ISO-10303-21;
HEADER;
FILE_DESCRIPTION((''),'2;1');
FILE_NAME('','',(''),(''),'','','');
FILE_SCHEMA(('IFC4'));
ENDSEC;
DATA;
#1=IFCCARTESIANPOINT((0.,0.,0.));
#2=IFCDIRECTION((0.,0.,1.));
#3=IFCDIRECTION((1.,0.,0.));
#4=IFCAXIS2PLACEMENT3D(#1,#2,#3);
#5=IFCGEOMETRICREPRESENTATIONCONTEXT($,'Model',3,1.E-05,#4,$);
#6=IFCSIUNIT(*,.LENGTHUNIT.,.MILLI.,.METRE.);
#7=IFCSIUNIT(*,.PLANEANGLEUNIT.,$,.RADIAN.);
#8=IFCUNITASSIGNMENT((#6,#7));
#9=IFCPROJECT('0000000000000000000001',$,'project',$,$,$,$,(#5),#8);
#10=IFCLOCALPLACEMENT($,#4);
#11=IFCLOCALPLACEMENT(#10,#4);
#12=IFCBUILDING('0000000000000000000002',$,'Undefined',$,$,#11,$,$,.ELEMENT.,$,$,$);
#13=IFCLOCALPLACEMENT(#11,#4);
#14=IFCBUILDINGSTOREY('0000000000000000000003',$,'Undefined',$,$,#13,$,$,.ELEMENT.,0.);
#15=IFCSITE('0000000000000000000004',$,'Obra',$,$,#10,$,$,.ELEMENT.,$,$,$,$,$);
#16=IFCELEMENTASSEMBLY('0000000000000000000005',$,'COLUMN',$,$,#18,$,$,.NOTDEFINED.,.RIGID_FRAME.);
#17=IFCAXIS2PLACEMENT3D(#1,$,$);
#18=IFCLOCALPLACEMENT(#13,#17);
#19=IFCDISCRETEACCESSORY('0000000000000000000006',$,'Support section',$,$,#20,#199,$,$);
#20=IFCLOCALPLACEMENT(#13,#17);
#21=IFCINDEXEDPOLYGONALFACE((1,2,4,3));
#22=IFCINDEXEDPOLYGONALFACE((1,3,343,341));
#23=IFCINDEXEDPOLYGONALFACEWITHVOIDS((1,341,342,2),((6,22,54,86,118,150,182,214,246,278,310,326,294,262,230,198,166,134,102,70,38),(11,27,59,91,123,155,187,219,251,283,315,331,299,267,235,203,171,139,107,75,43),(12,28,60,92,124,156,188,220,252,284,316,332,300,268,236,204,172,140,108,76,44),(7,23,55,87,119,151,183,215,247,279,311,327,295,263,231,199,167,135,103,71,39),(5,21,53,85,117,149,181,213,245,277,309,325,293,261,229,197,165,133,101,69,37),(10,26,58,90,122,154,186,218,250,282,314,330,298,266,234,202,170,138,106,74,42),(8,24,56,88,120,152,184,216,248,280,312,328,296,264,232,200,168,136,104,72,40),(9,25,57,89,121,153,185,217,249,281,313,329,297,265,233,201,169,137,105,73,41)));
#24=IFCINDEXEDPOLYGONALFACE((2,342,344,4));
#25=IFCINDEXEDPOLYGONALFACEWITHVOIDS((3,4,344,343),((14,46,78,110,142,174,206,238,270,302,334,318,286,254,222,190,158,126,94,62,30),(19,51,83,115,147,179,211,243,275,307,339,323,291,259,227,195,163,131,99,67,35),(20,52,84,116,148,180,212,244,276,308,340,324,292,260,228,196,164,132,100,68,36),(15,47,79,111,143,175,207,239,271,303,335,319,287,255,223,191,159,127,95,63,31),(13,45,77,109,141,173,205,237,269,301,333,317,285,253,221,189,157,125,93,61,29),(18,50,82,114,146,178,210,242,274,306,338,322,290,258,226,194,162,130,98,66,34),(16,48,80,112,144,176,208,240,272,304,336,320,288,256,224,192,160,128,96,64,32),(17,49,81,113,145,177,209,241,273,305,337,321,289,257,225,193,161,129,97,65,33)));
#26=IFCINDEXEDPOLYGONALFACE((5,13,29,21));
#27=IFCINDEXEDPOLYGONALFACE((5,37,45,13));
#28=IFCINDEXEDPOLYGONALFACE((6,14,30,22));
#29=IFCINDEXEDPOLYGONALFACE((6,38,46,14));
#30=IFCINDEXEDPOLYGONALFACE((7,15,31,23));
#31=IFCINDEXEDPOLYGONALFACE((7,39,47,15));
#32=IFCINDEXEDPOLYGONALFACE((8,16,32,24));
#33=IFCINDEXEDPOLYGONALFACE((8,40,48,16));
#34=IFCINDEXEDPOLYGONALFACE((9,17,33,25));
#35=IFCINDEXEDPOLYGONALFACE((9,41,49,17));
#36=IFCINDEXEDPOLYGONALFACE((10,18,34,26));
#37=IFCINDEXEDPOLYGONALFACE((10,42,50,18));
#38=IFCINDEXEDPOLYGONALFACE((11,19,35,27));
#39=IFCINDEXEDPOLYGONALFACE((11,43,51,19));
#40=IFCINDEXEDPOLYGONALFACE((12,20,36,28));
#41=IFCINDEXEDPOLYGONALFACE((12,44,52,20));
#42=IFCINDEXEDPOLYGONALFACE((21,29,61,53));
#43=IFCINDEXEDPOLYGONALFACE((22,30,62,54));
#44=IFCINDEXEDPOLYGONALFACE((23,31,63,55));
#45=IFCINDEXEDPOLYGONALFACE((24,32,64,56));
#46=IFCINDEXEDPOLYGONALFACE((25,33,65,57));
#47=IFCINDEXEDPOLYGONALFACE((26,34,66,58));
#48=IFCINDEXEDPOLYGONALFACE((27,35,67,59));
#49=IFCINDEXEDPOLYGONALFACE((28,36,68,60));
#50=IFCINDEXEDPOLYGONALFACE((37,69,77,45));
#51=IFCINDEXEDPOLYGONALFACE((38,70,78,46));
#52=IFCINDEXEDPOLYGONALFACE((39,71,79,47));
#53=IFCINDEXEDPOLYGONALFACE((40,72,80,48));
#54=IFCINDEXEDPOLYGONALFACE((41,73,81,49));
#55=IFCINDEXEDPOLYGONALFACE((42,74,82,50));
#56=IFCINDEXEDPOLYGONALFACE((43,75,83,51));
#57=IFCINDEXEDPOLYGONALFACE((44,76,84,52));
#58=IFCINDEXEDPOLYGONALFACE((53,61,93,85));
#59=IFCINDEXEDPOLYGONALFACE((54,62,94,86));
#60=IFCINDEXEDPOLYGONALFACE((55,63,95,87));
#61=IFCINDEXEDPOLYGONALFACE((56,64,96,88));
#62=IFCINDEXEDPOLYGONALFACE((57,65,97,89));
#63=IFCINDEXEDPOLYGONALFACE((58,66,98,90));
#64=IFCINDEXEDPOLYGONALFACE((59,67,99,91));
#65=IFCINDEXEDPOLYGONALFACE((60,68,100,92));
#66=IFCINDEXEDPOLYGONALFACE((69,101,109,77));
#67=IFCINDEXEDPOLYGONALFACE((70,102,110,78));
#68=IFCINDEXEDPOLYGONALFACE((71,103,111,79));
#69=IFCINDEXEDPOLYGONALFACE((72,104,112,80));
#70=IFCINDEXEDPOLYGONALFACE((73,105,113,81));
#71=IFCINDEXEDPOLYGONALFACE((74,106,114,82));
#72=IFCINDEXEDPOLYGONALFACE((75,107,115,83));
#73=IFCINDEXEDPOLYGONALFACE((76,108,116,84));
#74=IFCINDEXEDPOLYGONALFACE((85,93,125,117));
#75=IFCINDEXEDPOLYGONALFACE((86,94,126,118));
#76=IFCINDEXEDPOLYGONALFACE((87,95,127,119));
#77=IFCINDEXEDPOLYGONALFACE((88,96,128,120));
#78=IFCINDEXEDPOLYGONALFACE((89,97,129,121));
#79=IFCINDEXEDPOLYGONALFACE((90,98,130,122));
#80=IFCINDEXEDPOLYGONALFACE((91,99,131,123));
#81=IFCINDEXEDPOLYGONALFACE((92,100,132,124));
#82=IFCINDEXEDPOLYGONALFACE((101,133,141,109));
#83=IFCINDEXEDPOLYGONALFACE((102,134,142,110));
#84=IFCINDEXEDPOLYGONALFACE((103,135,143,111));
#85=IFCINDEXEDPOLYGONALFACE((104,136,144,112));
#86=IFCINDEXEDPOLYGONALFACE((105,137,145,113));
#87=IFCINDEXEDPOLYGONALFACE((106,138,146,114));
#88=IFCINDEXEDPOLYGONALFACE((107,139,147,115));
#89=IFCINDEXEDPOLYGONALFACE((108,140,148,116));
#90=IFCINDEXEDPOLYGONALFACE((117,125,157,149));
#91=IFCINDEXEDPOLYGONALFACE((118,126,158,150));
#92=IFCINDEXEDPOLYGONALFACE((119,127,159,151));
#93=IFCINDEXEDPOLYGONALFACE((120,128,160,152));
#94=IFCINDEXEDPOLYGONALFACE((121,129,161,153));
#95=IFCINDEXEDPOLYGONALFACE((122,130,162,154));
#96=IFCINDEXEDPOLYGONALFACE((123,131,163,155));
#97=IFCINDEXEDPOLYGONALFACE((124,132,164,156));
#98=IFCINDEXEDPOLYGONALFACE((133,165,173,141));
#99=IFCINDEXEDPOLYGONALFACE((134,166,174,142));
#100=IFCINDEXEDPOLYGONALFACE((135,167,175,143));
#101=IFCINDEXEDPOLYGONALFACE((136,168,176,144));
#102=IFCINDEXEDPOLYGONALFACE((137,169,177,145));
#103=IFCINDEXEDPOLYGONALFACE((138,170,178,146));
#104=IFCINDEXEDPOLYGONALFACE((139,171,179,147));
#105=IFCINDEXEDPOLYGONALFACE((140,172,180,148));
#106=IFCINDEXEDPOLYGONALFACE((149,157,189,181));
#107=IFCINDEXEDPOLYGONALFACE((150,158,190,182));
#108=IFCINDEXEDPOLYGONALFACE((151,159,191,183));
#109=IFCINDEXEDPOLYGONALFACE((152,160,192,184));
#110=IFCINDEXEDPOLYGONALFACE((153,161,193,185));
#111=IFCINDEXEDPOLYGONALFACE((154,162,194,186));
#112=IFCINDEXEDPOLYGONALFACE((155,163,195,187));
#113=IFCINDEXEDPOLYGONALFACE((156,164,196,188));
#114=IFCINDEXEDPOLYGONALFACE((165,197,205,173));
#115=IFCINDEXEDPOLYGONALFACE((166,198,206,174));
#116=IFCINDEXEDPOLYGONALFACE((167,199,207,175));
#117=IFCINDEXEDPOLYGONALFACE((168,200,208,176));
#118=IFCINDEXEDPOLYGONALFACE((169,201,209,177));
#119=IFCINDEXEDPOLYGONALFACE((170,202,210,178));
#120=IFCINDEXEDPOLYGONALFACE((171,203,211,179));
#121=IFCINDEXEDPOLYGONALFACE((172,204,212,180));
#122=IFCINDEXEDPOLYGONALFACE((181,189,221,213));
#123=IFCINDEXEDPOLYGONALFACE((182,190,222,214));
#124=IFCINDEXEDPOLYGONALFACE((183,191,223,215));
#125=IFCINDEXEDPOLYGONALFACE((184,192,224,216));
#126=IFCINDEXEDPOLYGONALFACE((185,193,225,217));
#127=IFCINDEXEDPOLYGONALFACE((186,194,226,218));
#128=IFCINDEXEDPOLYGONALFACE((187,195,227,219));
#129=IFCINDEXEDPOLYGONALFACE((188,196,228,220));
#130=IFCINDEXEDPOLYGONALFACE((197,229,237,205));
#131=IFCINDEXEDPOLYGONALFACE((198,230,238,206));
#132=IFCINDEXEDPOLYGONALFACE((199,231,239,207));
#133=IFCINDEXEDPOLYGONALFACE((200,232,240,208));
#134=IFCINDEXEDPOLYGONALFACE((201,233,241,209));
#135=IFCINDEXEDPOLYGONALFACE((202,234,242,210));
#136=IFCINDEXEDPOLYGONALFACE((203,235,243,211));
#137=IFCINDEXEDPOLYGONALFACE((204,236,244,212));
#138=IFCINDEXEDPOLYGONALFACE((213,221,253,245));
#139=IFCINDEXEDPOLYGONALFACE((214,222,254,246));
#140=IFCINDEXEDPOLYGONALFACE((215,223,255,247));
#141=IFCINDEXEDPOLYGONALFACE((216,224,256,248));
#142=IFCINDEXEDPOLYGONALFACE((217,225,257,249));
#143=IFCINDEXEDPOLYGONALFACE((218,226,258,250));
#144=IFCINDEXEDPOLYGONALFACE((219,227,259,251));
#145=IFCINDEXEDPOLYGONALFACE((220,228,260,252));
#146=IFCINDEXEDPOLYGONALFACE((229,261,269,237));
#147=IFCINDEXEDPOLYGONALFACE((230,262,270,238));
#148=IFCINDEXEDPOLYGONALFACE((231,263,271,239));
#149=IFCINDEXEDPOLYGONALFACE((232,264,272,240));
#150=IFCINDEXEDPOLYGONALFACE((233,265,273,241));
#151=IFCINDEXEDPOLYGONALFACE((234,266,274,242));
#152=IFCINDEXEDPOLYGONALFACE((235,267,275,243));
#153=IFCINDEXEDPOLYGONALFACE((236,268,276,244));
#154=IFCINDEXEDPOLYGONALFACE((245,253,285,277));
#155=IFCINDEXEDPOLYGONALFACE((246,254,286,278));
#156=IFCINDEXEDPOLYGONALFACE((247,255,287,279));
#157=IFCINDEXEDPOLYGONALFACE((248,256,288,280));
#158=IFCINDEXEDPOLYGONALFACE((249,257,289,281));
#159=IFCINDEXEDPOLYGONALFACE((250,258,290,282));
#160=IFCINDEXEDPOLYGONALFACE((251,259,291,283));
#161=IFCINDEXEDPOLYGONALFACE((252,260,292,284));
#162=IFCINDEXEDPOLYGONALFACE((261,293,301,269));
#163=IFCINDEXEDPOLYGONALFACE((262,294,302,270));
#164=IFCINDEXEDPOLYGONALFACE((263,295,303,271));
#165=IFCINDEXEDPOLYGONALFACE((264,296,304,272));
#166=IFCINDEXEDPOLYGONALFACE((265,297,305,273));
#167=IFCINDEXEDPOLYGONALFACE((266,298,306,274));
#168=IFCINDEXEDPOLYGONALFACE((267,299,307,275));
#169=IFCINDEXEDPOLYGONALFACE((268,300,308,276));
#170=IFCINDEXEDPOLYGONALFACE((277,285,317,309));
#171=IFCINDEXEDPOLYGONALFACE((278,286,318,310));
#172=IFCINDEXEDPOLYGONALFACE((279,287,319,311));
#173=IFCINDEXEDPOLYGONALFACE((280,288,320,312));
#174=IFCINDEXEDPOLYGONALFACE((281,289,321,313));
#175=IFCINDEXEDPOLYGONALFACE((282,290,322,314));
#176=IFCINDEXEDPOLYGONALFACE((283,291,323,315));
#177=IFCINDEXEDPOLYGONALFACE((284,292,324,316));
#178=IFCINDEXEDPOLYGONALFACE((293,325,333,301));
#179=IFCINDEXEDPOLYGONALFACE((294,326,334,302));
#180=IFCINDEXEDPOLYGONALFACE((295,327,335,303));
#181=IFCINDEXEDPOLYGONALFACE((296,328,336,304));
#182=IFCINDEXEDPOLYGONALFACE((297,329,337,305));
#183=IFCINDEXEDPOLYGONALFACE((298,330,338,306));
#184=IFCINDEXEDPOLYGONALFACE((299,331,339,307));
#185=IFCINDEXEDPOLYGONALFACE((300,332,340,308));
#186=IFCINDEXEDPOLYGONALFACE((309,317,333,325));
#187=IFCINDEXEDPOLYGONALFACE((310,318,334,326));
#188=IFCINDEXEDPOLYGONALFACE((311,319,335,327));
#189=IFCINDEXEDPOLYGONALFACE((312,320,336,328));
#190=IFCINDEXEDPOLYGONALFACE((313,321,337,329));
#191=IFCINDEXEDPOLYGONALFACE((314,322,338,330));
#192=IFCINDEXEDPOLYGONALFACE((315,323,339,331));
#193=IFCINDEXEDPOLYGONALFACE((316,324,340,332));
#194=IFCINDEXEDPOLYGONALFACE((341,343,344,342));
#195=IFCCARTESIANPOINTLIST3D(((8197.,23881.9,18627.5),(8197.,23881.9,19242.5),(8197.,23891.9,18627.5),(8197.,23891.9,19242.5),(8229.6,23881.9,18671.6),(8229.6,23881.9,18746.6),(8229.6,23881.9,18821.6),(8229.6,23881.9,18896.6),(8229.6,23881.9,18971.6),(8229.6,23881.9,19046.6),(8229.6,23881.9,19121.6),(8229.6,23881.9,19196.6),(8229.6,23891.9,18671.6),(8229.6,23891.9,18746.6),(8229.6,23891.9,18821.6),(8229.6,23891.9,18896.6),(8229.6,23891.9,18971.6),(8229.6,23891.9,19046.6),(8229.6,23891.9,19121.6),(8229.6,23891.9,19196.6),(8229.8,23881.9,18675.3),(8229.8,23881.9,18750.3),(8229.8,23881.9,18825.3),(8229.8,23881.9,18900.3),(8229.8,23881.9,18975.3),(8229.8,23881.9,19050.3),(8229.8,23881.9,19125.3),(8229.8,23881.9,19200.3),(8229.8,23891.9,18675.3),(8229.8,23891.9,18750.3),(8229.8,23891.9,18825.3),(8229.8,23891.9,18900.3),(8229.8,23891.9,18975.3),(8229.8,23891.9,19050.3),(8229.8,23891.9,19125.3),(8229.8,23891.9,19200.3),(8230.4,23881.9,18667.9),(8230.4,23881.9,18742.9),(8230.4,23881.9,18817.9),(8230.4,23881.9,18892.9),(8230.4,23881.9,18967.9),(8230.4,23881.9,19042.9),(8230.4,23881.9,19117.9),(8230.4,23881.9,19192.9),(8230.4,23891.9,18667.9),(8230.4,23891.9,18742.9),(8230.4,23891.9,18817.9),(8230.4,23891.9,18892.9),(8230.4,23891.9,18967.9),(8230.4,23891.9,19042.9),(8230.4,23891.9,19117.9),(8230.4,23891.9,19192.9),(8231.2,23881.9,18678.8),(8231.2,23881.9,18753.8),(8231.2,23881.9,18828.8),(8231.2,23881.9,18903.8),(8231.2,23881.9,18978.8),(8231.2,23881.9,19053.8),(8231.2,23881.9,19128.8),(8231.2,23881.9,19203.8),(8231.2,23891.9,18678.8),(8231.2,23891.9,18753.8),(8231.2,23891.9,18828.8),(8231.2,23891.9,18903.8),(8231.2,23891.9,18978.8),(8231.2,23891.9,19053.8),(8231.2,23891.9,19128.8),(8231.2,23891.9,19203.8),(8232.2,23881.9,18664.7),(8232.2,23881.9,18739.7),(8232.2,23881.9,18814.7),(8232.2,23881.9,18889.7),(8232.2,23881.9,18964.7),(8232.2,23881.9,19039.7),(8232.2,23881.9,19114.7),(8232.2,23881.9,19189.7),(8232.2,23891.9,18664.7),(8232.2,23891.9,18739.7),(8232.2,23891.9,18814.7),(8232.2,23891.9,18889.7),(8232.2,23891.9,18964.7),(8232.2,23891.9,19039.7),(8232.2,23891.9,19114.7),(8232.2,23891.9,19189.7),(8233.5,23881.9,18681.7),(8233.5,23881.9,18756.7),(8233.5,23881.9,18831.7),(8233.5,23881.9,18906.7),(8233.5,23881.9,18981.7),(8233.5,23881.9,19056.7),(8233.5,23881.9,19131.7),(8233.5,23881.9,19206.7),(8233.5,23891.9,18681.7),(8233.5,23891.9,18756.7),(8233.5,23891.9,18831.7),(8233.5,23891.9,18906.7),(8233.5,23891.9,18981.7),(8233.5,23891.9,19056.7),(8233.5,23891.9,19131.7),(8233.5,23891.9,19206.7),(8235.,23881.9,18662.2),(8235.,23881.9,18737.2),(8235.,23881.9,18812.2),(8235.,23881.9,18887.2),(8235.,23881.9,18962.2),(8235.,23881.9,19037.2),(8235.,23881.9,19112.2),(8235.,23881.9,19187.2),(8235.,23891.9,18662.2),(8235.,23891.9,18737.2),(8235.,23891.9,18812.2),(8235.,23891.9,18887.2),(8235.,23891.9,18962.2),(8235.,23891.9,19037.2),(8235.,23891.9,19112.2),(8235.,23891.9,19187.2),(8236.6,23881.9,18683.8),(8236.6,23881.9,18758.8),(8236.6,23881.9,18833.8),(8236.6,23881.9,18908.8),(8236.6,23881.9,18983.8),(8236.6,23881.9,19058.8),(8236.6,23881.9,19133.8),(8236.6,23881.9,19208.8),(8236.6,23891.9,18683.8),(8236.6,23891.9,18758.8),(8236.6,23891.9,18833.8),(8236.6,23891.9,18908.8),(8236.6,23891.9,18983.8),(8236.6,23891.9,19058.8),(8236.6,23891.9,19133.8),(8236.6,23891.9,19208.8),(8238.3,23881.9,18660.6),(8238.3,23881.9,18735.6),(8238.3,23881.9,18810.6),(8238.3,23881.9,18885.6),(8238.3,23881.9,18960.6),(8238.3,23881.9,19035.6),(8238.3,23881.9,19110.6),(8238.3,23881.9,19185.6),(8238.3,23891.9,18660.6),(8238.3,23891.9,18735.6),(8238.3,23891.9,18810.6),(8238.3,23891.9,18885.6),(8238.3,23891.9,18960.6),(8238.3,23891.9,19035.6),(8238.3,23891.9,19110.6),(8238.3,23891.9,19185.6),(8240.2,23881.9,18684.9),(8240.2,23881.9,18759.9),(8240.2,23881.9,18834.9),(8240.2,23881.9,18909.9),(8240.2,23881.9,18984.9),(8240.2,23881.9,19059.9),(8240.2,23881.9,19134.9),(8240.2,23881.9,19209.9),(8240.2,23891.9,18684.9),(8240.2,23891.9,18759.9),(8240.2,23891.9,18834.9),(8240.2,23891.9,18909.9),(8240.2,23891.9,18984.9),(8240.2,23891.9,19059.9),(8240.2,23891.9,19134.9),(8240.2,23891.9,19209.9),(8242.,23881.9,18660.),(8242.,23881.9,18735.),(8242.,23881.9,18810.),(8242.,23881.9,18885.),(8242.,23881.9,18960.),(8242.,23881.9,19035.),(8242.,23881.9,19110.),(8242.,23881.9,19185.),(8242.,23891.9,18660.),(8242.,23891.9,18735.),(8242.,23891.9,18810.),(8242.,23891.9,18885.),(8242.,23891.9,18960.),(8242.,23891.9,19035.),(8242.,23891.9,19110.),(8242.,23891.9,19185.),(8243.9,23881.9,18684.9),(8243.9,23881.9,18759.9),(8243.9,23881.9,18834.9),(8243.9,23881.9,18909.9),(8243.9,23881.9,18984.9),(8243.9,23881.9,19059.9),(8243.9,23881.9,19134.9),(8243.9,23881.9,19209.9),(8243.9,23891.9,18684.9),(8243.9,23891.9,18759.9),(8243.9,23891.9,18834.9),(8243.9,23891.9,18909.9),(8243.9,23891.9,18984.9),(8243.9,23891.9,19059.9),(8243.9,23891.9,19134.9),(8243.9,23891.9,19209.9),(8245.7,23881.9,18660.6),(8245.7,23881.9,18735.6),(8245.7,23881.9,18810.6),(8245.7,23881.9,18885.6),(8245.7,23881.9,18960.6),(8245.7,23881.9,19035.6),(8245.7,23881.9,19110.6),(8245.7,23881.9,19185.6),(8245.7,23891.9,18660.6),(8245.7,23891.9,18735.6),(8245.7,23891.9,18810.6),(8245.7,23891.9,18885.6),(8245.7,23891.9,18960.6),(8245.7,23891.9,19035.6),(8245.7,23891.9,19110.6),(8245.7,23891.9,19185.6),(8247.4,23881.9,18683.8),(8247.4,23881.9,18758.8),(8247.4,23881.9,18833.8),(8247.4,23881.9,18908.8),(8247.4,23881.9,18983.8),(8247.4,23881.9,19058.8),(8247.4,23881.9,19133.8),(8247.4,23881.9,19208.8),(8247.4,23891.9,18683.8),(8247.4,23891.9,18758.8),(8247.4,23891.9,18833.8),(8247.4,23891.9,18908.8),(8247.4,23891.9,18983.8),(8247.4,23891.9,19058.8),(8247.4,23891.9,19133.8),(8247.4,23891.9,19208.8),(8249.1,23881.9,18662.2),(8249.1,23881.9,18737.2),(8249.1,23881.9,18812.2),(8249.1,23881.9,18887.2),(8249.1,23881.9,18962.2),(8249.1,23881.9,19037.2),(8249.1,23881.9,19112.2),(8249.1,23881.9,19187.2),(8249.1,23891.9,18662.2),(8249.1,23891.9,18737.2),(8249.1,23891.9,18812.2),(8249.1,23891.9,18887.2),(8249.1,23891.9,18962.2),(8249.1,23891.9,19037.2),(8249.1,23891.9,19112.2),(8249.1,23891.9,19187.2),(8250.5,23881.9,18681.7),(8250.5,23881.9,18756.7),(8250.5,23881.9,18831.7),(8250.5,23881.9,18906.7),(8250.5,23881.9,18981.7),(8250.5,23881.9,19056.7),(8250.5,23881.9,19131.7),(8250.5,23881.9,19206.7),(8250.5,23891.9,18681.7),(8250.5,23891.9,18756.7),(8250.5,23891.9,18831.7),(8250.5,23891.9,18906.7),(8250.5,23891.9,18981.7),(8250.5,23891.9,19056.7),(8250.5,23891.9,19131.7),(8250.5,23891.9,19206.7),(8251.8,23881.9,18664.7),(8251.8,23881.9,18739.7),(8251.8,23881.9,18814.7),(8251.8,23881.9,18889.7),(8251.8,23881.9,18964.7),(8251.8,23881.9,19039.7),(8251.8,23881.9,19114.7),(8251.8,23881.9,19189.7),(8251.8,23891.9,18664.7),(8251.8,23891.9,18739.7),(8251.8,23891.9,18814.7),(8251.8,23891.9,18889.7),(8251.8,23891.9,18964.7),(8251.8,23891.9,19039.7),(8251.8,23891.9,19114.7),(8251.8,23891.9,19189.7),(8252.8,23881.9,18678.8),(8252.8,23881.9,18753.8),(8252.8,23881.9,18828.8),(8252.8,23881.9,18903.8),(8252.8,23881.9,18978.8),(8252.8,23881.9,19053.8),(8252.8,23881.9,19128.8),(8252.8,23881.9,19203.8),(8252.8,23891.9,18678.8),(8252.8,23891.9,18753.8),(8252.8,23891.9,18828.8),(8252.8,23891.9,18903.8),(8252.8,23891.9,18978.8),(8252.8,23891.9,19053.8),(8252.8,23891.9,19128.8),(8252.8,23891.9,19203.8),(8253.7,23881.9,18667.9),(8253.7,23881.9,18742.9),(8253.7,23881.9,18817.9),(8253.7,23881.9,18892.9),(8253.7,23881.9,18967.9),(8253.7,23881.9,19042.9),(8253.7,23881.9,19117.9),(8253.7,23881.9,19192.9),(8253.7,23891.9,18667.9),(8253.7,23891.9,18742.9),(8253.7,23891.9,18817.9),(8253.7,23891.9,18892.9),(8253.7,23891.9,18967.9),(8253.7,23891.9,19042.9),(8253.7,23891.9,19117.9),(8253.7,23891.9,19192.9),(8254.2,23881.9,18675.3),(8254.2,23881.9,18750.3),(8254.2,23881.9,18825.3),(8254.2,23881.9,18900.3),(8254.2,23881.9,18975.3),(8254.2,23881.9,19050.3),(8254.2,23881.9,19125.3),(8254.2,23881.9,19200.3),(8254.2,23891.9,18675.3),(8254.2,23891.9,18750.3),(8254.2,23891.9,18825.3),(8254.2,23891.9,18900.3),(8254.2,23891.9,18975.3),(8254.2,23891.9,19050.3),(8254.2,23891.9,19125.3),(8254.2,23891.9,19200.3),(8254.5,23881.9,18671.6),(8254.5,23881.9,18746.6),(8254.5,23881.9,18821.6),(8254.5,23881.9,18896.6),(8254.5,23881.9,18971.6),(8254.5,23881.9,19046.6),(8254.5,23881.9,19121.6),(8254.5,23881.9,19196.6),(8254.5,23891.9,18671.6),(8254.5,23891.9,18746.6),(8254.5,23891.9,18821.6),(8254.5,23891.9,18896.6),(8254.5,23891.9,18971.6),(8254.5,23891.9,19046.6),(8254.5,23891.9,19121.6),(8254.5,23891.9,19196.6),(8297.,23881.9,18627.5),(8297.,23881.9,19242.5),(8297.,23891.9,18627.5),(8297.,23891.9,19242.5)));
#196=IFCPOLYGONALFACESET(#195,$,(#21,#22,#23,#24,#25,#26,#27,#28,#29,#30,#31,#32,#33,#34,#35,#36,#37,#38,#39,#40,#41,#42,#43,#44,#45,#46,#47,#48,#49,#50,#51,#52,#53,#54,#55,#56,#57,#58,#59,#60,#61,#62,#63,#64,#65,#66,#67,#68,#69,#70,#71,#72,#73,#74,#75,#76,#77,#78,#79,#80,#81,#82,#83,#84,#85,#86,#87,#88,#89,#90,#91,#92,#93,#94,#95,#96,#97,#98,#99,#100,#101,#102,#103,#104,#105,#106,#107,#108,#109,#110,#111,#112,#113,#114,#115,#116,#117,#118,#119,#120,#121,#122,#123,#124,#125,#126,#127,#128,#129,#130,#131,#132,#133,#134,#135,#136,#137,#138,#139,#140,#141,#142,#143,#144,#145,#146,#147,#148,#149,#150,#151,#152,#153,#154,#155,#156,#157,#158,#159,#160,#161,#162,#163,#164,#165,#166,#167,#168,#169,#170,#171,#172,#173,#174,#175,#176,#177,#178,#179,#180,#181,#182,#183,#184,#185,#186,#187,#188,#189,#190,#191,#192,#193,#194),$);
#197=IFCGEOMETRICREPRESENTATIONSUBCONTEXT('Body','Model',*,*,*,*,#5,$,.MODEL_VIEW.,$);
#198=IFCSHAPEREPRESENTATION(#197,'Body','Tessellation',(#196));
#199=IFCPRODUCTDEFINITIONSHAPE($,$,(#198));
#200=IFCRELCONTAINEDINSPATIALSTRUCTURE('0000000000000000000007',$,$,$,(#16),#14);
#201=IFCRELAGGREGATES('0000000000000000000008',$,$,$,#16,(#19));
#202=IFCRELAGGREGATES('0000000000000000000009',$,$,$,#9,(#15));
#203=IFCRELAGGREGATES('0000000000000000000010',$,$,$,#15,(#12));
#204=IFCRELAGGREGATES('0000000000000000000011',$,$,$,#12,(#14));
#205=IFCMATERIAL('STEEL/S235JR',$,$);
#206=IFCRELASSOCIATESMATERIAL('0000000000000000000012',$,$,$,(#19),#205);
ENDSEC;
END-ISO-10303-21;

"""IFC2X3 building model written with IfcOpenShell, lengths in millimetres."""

from ifc_helpers import new_model, si_unit, frame, origin_with_axes, origin_2d_with_axis, place, context, subcontext, project, spatial, rectangle, circle, extrude, source, transform, mapped, material, element, aggregate, save


model = new_model("IFC2X3")

# Units and contexts
model_context = context("Model", 3, precision=1e-05, world=origin_with_axes())
body_context = subcontext(model_context, "Body", "Model", "MODEL_VIEW")
ifc_project = project(units=[si_unit("LENGTHUNIT", "METRE", prefix="MILLI"), si_unit("PLANEANGLEUNIT", "RADIAN")], contexts=[model_context])

# Site, building, storey
site_placement = place(None, origin_with_axes())
site = spatial("IfcSite", under=ifc_project, at=site_placement, Name="Obra", CompositionType="ELEMENT")
building_placement = place(site_placement, origin_with_axes())
building = spatial("IfcBuilding", under=site, at=building_placement, Name="Undefined", CompositionType="ELEMENT")
storey_placement = place(building_placement, origin_with_axes())
storey = spatial("IfcBuildingStorey", under=building, at=storey_placement, Name="Undefined", CompositionType="ELEMENT", Elevation=0.0)

# Element assembly
assembly_1_placement = place(storey_placement, origin_with_axes())
assembly_1 = element("IfcElementAssembly", 1, at=assembly_1_placement, inside=storey, Name="COLUMN", AssemblyPlace="NOTDEFINED", PredefinedType="RIGID_FRAME")
ifc_material_1 = material(Name="STEEL/S235JR")

# Discrete accessory, opening
discrete_accessory_1_placement = place(assembly_1_placement, frame((8247.0, 23886.9, 18627.5), z_axis=(0.0, 0.0, 1.0), x_axis=(1.0, 0.0, 0.0)))
discrete_accessory_1 = element("IfcDiscreteAccessory", 2, at=discrete_accessory_1_placement, material=ifc_material_1, Name="Support section", context=body_context, shape_type="SweptSolid", body=[
    extrude(rectangle(XDim=10.0, YDim=100.0, at=origin_2d_with_axis()), frame((0.0, 0.0, 615.0), z_axis=(0.0, 0.0, -1.0), x_axis=(0.0, 1.0, 0.0)), (0.0, 0.0, 1.0), 615.0),
])
shared_shape_1 = source(origin_with_axes(), body_context, "Body", "SweptSolid", [
    extrude(circle(Radius=12.5, at=origin_2d_with_axis()), frame((0.0, 4.9, 0.0), z_axis=(0.0, 1.0, 0.0), x_axis=(1.0, 0.0, 0.0)), (0.0, 0.0, 1.0), 10.2),
])
opening_1_placement = place(assembly_1_placement, frame((8287.0, 23896.9, 19350.0), z_axis=(-1.0, 0.0, 0.0), x_axis=(0.0, 0.0, -1.0)))
element("IfcOpeningElement", 3, at=opening_1_placement, cuts=discrete_accessory_1, ObjectType="Opening", context=body_context, shape_type="MappedRepresentation", body=[
    mapped(shared_shape_1, transform((152.5, 0.0, 45.0))),
    mapped(shared_shape_1, transform((227.5, 0.0, 45.0))),
    mapped(shared_shape_1, transform((302.5, 0.0, 45.0))),
    mapped(shared_shape_1, transform((377.5, 0.0, 45.0))),
    mapped(shared_shape_1, transform((452.5, 0.0, 45.0))),
    mapped(shared_shape_1, transform((527.5, 0.0, 45.0))),
    mapped(shared_shape_1, transform((602.5, 0.0, 45.0))),
    mapped(shared_shape_1, transform((677.5, 0.0, 45.0))),
])
aggregate(assembly_1, [discrete_accessory_1])

save(model, "model.ifc")
